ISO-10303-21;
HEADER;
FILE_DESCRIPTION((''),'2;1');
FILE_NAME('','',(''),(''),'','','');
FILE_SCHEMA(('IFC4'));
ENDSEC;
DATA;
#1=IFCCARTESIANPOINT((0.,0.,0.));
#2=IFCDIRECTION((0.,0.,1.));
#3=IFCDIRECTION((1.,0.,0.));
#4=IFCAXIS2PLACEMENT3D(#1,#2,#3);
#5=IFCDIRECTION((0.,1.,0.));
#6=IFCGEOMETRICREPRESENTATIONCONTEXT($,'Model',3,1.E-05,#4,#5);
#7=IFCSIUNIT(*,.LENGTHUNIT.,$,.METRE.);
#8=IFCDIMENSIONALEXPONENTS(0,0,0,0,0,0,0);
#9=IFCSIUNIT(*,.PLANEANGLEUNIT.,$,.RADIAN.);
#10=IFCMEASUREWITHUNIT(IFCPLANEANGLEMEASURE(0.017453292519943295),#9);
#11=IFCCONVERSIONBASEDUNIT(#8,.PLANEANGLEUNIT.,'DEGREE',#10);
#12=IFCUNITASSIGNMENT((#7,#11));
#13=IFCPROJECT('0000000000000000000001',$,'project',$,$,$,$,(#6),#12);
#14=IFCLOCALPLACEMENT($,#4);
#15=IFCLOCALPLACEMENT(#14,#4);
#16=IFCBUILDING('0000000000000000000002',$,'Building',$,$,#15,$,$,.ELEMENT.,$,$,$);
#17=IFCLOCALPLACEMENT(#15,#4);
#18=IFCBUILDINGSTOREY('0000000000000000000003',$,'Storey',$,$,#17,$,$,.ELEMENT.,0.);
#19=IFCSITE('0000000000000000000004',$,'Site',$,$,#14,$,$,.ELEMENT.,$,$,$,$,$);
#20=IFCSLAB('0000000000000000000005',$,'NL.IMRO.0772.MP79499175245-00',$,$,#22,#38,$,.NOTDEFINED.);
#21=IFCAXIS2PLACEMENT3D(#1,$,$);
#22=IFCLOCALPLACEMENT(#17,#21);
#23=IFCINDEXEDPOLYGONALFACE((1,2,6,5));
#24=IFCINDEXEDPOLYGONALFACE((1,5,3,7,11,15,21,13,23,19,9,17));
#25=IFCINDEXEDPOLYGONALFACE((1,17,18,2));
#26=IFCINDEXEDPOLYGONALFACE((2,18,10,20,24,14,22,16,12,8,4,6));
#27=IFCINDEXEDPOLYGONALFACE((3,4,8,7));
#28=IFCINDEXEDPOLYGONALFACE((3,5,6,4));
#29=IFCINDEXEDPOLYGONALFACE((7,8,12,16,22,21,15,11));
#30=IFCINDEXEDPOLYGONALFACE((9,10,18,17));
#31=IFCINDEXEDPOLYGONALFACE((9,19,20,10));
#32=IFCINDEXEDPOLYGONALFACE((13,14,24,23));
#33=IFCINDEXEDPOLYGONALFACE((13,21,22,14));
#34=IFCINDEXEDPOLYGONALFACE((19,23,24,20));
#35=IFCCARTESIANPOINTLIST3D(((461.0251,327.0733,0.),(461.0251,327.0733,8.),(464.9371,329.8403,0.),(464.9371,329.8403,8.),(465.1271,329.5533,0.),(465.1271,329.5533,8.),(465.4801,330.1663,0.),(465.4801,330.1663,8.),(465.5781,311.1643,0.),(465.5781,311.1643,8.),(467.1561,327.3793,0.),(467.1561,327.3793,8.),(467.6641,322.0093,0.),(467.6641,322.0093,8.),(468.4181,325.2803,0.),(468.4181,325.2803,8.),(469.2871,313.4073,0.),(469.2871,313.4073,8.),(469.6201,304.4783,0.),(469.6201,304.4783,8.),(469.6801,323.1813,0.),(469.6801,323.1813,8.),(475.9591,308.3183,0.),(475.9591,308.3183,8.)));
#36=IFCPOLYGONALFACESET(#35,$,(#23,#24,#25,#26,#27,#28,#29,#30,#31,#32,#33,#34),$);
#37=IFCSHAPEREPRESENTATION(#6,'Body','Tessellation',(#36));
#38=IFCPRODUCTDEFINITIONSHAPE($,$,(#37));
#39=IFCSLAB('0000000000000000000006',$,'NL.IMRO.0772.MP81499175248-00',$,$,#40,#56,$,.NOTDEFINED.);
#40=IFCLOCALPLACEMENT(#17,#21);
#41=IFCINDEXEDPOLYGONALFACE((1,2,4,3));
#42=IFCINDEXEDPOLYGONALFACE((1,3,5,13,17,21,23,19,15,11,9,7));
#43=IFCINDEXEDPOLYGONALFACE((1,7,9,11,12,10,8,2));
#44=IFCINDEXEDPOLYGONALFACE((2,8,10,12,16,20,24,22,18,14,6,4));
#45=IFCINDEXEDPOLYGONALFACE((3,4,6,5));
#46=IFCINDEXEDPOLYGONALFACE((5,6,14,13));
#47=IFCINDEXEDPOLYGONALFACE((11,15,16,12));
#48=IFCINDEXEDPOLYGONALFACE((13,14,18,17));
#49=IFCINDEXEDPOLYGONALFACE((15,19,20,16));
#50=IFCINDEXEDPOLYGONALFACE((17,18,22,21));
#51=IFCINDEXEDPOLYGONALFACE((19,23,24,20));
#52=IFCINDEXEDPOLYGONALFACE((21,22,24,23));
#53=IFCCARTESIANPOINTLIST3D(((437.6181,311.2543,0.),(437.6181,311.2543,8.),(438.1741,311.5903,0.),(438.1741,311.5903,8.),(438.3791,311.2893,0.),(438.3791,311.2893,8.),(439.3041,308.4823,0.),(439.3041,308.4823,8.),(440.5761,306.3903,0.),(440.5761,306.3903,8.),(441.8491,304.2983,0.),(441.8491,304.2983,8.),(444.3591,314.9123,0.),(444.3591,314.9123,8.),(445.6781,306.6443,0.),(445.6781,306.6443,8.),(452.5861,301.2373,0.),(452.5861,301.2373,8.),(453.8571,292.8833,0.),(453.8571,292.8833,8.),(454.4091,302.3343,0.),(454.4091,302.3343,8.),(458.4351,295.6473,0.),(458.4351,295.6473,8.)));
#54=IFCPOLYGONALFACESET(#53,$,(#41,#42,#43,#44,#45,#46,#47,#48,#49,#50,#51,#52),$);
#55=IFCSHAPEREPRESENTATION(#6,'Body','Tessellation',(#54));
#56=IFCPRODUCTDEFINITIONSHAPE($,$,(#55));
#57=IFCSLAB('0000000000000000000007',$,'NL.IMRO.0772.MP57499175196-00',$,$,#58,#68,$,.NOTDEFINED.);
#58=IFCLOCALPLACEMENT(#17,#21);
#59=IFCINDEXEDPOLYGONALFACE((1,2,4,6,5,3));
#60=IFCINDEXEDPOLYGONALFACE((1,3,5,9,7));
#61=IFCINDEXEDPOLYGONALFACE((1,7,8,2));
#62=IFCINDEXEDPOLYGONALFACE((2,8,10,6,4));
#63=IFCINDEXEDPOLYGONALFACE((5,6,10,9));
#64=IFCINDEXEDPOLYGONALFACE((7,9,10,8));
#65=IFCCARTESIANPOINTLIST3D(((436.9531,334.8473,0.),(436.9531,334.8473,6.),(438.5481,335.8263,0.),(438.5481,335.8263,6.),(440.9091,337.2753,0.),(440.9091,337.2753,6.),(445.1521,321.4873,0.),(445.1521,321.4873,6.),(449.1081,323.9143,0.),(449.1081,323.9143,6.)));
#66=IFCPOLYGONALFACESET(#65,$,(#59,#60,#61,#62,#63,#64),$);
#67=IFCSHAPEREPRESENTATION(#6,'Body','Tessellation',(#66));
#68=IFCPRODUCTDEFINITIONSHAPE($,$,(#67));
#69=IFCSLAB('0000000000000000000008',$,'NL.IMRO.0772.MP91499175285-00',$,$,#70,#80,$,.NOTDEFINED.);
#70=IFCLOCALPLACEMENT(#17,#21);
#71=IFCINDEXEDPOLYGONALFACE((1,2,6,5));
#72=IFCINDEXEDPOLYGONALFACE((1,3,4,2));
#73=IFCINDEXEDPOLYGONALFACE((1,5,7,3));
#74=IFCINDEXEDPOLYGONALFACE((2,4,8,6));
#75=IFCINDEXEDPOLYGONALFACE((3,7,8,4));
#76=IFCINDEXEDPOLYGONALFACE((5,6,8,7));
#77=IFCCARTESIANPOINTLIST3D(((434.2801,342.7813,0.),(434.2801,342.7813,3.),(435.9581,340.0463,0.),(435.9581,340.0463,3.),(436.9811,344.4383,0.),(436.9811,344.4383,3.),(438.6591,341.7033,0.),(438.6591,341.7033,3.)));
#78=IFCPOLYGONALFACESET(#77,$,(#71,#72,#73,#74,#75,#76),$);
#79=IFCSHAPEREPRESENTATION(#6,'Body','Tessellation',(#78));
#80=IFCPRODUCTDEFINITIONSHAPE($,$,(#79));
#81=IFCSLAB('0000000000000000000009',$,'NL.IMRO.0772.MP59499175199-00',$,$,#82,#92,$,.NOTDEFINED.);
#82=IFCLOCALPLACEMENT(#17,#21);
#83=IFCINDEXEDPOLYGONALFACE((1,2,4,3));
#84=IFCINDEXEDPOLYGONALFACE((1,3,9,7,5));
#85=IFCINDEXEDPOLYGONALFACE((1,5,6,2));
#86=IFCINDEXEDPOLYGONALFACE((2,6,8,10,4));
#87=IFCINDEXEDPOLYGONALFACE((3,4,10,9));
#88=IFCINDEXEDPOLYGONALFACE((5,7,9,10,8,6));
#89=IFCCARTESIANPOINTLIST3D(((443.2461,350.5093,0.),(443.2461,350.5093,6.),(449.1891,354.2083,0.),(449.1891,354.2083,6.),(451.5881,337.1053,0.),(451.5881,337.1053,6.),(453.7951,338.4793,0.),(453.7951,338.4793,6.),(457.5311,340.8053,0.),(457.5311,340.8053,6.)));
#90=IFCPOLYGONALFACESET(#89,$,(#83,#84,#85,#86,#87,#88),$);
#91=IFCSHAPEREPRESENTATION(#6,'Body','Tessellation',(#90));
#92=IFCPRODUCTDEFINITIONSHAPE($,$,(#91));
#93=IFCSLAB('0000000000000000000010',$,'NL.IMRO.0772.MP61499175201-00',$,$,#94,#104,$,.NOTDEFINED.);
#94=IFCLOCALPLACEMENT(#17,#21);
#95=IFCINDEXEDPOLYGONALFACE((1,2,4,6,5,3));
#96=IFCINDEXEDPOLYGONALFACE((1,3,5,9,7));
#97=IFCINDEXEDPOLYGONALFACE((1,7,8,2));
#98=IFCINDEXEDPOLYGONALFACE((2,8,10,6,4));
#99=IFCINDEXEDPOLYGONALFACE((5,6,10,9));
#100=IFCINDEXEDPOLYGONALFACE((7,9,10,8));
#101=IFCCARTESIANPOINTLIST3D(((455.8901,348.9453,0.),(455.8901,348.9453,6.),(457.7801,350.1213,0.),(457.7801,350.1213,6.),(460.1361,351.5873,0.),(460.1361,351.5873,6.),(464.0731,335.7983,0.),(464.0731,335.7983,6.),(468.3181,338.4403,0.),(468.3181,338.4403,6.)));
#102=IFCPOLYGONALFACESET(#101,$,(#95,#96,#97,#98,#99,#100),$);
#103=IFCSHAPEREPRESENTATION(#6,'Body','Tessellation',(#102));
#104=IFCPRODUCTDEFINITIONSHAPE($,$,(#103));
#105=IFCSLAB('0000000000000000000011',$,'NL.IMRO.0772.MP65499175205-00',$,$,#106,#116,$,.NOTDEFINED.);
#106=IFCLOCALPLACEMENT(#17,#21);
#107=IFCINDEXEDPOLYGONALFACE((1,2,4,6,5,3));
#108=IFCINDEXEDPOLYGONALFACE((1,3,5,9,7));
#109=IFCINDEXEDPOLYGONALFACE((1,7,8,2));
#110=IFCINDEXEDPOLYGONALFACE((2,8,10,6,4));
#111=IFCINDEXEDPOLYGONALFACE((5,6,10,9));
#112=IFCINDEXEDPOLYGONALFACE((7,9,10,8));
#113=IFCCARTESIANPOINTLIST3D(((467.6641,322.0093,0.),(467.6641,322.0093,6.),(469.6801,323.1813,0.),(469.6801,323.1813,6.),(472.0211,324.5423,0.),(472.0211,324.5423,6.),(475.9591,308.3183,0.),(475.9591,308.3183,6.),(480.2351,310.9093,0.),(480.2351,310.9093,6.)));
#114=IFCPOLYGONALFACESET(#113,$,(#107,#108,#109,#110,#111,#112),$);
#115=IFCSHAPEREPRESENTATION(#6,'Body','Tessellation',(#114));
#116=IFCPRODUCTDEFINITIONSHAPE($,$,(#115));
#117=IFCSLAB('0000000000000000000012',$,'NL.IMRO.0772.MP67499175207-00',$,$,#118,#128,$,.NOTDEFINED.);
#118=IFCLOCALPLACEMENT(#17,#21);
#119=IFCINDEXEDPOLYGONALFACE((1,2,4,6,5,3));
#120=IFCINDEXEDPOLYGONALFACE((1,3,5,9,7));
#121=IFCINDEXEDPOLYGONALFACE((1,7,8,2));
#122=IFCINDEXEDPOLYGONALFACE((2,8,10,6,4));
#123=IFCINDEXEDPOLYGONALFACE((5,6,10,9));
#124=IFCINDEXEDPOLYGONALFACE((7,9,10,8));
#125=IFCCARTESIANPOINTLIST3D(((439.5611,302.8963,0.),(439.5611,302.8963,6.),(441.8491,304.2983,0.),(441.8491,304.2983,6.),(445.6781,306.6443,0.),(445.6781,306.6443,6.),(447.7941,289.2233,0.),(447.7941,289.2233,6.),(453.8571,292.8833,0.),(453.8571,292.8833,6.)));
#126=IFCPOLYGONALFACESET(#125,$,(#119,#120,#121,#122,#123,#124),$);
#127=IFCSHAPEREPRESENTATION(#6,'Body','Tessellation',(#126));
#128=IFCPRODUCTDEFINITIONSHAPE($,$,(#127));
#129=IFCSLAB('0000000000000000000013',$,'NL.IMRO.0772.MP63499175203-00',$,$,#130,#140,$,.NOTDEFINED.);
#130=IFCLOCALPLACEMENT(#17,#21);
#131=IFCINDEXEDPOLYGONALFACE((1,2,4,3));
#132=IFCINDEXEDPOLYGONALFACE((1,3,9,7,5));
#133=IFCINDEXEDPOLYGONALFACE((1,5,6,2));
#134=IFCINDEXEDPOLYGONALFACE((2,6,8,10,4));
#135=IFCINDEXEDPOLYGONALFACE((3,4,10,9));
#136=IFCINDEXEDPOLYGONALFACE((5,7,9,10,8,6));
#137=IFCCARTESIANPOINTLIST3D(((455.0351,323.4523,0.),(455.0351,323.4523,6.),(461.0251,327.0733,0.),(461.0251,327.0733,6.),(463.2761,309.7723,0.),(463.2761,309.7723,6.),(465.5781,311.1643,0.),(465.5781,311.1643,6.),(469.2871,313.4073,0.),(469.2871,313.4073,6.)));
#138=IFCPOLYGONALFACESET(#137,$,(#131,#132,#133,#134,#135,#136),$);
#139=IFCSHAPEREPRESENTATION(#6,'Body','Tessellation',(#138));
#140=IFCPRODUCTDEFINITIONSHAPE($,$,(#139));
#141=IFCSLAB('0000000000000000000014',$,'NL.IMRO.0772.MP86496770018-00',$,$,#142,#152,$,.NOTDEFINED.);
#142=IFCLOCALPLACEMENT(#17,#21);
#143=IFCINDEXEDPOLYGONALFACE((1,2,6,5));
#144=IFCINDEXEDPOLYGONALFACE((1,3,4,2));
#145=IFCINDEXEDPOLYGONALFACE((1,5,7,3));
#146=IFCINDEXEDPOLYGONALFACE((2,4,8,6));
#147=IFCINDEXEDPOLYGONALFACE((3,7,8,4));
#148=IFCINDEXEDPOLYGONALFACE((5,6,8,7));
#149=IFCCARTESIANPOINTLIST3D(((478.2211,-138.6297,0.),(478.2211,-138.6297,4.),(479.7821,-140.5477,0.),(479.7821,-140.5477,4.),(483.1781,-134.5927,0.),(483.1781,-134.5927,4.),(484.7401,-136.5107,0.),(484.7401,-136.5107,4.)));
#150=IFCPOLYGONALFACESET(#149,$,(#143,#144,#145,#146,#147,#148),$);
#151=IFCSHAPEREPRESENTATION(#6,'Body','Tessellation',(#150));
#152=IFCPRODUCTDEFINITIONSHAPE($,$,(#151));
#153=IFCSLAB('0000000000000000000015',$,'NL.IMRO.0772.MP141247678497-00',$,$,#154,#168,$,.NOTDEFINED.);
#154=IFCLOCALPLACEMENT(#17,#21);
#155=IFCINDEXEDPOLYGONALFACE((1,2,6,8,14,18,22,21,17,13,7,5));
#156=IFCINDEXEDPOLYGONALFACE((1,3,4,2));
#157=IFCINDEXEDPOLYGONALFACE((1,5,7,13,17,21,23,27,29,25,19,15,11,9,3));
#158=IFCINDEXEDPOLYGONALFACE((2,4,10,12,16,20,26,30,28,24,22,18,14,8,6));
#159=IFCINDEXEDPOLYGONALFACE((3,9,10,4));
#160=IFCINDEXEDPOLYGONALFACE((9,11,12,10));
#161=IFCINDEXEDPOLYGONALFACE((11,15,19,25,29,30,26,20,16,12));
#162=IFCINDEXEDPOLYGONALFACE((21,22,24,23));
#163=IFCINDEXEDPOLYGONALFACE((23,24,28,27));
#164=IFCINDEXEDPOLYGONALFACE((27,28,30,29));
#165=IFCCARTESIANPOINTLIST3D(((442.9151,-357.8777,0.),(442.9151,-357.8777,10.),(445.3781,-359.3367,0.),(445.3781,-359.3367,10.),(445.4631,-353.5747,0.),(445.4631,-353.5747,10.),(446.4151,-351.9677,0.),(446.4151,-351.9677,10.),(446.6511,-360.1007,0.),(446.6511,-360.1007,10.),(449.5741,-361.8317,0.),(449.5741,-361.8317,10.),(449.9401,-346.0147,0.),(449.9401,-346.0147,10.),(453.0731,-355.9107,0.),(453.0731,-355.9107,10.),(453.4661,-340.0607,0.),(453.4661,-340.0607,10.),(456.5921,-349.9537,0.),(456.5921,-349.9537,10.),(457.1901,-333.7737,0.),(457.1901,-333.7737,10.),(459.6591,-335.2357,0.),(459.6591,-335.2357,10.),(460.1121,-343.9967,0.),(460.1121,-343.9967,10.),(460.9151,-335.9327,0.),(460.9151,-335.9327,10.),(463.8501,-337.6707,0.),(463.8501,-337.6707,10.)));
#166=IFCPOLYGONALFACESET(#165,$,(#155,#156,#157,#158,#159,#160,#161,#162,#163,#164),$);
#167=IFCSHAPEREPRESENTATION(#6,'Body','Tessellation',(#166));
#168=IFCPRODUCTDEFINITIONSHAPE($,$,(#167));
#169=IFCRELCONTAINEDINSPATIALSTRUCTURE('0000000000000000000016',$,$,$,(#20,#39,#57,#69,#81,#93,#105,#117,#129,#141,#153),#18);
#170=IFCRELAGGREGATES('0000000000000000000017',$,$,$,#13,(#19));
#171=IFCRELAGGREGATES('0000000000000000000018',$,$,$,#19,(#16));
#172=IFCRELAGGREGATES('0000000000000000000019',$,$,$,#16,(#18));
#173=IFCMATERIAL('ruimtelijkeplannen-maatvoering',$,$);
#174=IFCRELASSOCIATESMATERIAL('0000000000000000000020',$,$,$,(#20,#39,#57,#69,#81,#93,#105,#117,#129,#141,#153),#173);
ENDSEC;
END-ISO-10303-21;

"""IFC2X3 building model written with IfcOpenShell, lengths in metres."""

from ifc_helpers import new_model, entity, si_unit, converted_unit, direction, origin_with_axes, place, context, project, spatial, polyline, outline, extrude, material, element, save


model = new_model("IFC2X3")

# Units and contexts
model_context = context("Model", 3, precision=1e-05, world=origin_with_axes(), true_north=direction((0.0, 1.0, 0.0)))
ifc_project = project(units=[si_unit("LENGTHUNIT", "METRE"), converted_unit("PLANEANGLEUNIT", "DEGREE", entity("IfcPlaneAngleMeasure", 0.017453292519943295), si_unit("PLANEANGLEUNIT", "RADIAN"), dimensions=[0, 0, 0, 0, 0, 0, 0])], contexts=[model_context])

# Site, building, storey
site_placement = place(None, origin_with_axes())
site = spatial("IfcSite", under=ifc_project, at=site_placement, Name="Site", CompositionType="ELEMENT")
building_placement = place(site_placement, origin_with_axes())
building = spatial("IfcBuilding", under=site, at=building_placement, Name="Building", CompositionType="ELEMENT")
storey_placement = place(building_placement, origin_with_axes())
storey = spatial("IfcBuildingStorey", under=building, at=storey_placement, Name="Storey", CompositionType="ELEMENT", Elevation=0.0)

# Slabs
ifc_material = material(Name="ruimtelijkeplannen-maatvoering")
slab_1_placement = place(storey_placement, origin_with_axes())
element("IfcSlab", 1, at=slab_1_placement, inside=storey, material=ifc_material, Name="NL.IMRO.0772.MP79499175245-00", PredefinedType="NOTDEFINED", context=model_context, shape_type="SweptSolid", body=[
    extrude(outline(polyline([(467.6641, 322.0093), (475.9591, 308.3183), (469.6201, 304.4783), (465.5781, 311.1643), (469.2871, 313.4073), (461.0251, 327.0733), (465.1271, 329.5533), (464.9371, 329.8403), (465.4801, 330.1663), (467.1561, 327.3793), (468.4181, 325.2803), (469.6801, 323.1813), (467.6641, 322.0093)])), origin_with_axes(), (0.0, 0.0, 1.0), 8.0),
])
slab_2_placement = place(storey_placement, origin_with_axes())
element("IfcSlab", 2, at=slab_2_placement, inside=storey, material=ifc_material, Name="NL.IMRO.0772.MP81499175248-00", PredefinedType="NOTDEFINED", context=model_context, shape_type="SweptSolid", body=[
    extrude(outline(polyline([(437.6181, 311.2543), (438.1741, 311.5903), (438.3791, 311.2893), (444.3591, 314.9123), (452.5861, 301.2373), (454.4091, 302.3343), (458.4351, 295.6473), (453.8571, 292.8833), (445.6781, 306.6443), (441.8491, 304.2983), (440.5761, 306.3903), (439.3041, 308.4823), (437.6181, 311.2543)])), origin_with_axes(), (0.0, 0.0, 1.0), 8.0),
])
slab_3_placement = place(storey_placement, origin_with_axes())
element("IfcSlab", 3, at=slab_3_placement, inside=storey, material=ifc_material, Name="NL.IMRO.0772.MP57499175196-00", PredefinedType="NOTDEFINED", context=model_context, shape_type="SweptSolid", body=[
    extrude(outline(polyline([(445.1521, 321.4873), (436.9531, 334.8473), (438.5481, 335.8263), (440.9091, 337.2753), (449.1081, 323.9143), (445.1521, 321.4873)])), origin_with_axes(), (0.0, 0.0, 1.0), 6.0),
])
slab_4_placement = place(storey_placement, origin_with_axes())
element("IfcSlab", 4, at=slab_4_placement, inside=storey, material=ifc_material, Name="NL.IMRO.0772.MP91499175285-00", PredefinedType="NOTDEFINED", context=model_context, shape_type="SweptSolid", body=[
    extrude(outline(polyline([(434.2801, 342.7813), (436.9811, 344.4383), (438.6591, 341.7033), (435.9581, 340.0463), (434.2801, 342.7813)])), origin_with_axes(), (0.0, 0.0, 1.0), 3.0),
])
slab_5_placement = place(storey_placement, origin_with_axes())
element("IfcSlab", 5, at=slab_5_placement, inside=storey, material=ifc_material, Name="NL.IMRO.0772.MP59499175199-00", PredefinedType="NOTDEFINED", context=model_context, shape_type="SweptSolid", body=[
    extrude(outline(polyline([(457.5311, 340.8053), (453.7951, 338.4793), (451.5881, 337.1053), (443.2461, 350.5093), (449.1891, 354.2083), (457.5311, 340.8053)])), origin_with_axes(), (0.0, 0.0, 1.0), 6.0),
])
slab_6_placement = place(storey_placement, origin_with_axes())
element("IfcSlab", 6, at=slab_6_placement, inside=storey, material=ifc_material, Name="NL.IMRO.0772.MP61499175201-00", PredefinedType="NOTDEFINED", context=model_context, shape_type="SweptSolid", body=[
    extrude(outline(polyline([(455.8901, 348.9453), (457.7801, 350.1213), (460.1361, 351.5873), (468.3181, 338.4403), (464.0731, 335.7983), (455.8901, 348.9453)])), origin_with_axes(), (0.0, 0.0, 1.0), 6.0),
])
slab_7_placement = place(storey_placement, origin_with_axes())
element("IfcSlab", 7, at=slab_7_placement, inside=storey, material=ifc_material, Name="NL.IMRO.0772.MP65499175205-00", PredefinedType="NOTDEFINED", context=model_context, shape_type="SweptSolid", body=[
    extrude(outline(polyline([(467.6641, 322.0093), (469.6801, 323.1813), (472.0211, 324.5423), (480.2351, 310.9093), (475.9591, 308.3183), (467.6641, 322.0093)])), origin_with_axes(), (0.0, 0.0, 1.0), 6.0),
])
slab_8_placement = place(storey_placement, origin_with_axes())
element("IfcSlab", 8, at=slab_8_placement, inside=storey, material=ifc_material, Name="NL.IMRO.0772.MP67499175207-00", PredefinedType="NOTDEFINED", context=model_context, shape_type="SweptSolid", body=[
    extrude(outline(polyline([(445.6781, 306.6443), (453.8571, 292.8833), (447.7941, 289.2233), (439.5611, 302.8963), (441.8491, 304.2983), (445.6781, 306.6443)])), origin_with_axes(), (0.0, 0.0, 1.0), 6.0),
])
slab_9_placement = place(storey_placement, origin_with_axes())
element("IfcSlab", 9, at=slab_9_placement, inside=storey, material=ifc_material, Name="NL.IMRO.0772.MP63499175203-00", PredefinedType="NOTDEFINED", context=model_context, shape_type="SweptSolid", body=[
    extrude(outline(polyline([(469.2871, 313.4073), (465.5781, 311.1643), (463.2761, 309.7723), (455.0351, 323.4523), (461.0251, 327.0733), (469.2871, 313.4073)])), origin_with_axes(), (0.0, 0.0, 1.0), 6.0),
])
slab_10_placement = place(storey_placement, origin_with_axes())
element("IfcSlab", 10, at=slab_10_placement, inside=storey, material=ifc_material, Name="NL.IMRO.0772.MP86496770018-00", PredefinedType="NOTDEFINED", context=model_context, shape_type="SweptSolid", body=[
    extrude(outline(polyline([(478.2211, -138.6297), (483.1781, -134.5927), (484.7401, -136.5107), (479.7821, -140.5477), (478.2211, -138.6297)])), origin_with_axes(), (0.0, 0.0, 1.0), 4.0),
])
slab_11_placement = place(storey_placement, origin_with_axes())
element("IfcSlab", 11, at=slab_11_placement, inside=storey, material=ifc_material, Name="NL.IMRO.0772.MP141247678497-00", PredefinedType="NOTDEFINED", context=model_context, shape_type="SweptSolid", body=[
    extrude(outline(polyline([(463.8501, -337.6707), (460.1121, -343.9967), (456.5921, -349.9537), (453.0731, -355.9107), (449.5741, -361.8317), (446.6511, -360.1007), (445.3781, -359.3367), (442.9151, -357.8777), (445.4631, -353.5747), (446.4151, -351.9677), (449.9401, -346.0147), (453.4661, -340.0607), (457.1901, -333.7737), (459.6591, -335.2357), (460.9151, -335.9327), (463.8501, -337.6707)])), origin_with_axes(), (0.0, 0.0, 1.0), 10.0),
])

save(model, "model.ifc")
